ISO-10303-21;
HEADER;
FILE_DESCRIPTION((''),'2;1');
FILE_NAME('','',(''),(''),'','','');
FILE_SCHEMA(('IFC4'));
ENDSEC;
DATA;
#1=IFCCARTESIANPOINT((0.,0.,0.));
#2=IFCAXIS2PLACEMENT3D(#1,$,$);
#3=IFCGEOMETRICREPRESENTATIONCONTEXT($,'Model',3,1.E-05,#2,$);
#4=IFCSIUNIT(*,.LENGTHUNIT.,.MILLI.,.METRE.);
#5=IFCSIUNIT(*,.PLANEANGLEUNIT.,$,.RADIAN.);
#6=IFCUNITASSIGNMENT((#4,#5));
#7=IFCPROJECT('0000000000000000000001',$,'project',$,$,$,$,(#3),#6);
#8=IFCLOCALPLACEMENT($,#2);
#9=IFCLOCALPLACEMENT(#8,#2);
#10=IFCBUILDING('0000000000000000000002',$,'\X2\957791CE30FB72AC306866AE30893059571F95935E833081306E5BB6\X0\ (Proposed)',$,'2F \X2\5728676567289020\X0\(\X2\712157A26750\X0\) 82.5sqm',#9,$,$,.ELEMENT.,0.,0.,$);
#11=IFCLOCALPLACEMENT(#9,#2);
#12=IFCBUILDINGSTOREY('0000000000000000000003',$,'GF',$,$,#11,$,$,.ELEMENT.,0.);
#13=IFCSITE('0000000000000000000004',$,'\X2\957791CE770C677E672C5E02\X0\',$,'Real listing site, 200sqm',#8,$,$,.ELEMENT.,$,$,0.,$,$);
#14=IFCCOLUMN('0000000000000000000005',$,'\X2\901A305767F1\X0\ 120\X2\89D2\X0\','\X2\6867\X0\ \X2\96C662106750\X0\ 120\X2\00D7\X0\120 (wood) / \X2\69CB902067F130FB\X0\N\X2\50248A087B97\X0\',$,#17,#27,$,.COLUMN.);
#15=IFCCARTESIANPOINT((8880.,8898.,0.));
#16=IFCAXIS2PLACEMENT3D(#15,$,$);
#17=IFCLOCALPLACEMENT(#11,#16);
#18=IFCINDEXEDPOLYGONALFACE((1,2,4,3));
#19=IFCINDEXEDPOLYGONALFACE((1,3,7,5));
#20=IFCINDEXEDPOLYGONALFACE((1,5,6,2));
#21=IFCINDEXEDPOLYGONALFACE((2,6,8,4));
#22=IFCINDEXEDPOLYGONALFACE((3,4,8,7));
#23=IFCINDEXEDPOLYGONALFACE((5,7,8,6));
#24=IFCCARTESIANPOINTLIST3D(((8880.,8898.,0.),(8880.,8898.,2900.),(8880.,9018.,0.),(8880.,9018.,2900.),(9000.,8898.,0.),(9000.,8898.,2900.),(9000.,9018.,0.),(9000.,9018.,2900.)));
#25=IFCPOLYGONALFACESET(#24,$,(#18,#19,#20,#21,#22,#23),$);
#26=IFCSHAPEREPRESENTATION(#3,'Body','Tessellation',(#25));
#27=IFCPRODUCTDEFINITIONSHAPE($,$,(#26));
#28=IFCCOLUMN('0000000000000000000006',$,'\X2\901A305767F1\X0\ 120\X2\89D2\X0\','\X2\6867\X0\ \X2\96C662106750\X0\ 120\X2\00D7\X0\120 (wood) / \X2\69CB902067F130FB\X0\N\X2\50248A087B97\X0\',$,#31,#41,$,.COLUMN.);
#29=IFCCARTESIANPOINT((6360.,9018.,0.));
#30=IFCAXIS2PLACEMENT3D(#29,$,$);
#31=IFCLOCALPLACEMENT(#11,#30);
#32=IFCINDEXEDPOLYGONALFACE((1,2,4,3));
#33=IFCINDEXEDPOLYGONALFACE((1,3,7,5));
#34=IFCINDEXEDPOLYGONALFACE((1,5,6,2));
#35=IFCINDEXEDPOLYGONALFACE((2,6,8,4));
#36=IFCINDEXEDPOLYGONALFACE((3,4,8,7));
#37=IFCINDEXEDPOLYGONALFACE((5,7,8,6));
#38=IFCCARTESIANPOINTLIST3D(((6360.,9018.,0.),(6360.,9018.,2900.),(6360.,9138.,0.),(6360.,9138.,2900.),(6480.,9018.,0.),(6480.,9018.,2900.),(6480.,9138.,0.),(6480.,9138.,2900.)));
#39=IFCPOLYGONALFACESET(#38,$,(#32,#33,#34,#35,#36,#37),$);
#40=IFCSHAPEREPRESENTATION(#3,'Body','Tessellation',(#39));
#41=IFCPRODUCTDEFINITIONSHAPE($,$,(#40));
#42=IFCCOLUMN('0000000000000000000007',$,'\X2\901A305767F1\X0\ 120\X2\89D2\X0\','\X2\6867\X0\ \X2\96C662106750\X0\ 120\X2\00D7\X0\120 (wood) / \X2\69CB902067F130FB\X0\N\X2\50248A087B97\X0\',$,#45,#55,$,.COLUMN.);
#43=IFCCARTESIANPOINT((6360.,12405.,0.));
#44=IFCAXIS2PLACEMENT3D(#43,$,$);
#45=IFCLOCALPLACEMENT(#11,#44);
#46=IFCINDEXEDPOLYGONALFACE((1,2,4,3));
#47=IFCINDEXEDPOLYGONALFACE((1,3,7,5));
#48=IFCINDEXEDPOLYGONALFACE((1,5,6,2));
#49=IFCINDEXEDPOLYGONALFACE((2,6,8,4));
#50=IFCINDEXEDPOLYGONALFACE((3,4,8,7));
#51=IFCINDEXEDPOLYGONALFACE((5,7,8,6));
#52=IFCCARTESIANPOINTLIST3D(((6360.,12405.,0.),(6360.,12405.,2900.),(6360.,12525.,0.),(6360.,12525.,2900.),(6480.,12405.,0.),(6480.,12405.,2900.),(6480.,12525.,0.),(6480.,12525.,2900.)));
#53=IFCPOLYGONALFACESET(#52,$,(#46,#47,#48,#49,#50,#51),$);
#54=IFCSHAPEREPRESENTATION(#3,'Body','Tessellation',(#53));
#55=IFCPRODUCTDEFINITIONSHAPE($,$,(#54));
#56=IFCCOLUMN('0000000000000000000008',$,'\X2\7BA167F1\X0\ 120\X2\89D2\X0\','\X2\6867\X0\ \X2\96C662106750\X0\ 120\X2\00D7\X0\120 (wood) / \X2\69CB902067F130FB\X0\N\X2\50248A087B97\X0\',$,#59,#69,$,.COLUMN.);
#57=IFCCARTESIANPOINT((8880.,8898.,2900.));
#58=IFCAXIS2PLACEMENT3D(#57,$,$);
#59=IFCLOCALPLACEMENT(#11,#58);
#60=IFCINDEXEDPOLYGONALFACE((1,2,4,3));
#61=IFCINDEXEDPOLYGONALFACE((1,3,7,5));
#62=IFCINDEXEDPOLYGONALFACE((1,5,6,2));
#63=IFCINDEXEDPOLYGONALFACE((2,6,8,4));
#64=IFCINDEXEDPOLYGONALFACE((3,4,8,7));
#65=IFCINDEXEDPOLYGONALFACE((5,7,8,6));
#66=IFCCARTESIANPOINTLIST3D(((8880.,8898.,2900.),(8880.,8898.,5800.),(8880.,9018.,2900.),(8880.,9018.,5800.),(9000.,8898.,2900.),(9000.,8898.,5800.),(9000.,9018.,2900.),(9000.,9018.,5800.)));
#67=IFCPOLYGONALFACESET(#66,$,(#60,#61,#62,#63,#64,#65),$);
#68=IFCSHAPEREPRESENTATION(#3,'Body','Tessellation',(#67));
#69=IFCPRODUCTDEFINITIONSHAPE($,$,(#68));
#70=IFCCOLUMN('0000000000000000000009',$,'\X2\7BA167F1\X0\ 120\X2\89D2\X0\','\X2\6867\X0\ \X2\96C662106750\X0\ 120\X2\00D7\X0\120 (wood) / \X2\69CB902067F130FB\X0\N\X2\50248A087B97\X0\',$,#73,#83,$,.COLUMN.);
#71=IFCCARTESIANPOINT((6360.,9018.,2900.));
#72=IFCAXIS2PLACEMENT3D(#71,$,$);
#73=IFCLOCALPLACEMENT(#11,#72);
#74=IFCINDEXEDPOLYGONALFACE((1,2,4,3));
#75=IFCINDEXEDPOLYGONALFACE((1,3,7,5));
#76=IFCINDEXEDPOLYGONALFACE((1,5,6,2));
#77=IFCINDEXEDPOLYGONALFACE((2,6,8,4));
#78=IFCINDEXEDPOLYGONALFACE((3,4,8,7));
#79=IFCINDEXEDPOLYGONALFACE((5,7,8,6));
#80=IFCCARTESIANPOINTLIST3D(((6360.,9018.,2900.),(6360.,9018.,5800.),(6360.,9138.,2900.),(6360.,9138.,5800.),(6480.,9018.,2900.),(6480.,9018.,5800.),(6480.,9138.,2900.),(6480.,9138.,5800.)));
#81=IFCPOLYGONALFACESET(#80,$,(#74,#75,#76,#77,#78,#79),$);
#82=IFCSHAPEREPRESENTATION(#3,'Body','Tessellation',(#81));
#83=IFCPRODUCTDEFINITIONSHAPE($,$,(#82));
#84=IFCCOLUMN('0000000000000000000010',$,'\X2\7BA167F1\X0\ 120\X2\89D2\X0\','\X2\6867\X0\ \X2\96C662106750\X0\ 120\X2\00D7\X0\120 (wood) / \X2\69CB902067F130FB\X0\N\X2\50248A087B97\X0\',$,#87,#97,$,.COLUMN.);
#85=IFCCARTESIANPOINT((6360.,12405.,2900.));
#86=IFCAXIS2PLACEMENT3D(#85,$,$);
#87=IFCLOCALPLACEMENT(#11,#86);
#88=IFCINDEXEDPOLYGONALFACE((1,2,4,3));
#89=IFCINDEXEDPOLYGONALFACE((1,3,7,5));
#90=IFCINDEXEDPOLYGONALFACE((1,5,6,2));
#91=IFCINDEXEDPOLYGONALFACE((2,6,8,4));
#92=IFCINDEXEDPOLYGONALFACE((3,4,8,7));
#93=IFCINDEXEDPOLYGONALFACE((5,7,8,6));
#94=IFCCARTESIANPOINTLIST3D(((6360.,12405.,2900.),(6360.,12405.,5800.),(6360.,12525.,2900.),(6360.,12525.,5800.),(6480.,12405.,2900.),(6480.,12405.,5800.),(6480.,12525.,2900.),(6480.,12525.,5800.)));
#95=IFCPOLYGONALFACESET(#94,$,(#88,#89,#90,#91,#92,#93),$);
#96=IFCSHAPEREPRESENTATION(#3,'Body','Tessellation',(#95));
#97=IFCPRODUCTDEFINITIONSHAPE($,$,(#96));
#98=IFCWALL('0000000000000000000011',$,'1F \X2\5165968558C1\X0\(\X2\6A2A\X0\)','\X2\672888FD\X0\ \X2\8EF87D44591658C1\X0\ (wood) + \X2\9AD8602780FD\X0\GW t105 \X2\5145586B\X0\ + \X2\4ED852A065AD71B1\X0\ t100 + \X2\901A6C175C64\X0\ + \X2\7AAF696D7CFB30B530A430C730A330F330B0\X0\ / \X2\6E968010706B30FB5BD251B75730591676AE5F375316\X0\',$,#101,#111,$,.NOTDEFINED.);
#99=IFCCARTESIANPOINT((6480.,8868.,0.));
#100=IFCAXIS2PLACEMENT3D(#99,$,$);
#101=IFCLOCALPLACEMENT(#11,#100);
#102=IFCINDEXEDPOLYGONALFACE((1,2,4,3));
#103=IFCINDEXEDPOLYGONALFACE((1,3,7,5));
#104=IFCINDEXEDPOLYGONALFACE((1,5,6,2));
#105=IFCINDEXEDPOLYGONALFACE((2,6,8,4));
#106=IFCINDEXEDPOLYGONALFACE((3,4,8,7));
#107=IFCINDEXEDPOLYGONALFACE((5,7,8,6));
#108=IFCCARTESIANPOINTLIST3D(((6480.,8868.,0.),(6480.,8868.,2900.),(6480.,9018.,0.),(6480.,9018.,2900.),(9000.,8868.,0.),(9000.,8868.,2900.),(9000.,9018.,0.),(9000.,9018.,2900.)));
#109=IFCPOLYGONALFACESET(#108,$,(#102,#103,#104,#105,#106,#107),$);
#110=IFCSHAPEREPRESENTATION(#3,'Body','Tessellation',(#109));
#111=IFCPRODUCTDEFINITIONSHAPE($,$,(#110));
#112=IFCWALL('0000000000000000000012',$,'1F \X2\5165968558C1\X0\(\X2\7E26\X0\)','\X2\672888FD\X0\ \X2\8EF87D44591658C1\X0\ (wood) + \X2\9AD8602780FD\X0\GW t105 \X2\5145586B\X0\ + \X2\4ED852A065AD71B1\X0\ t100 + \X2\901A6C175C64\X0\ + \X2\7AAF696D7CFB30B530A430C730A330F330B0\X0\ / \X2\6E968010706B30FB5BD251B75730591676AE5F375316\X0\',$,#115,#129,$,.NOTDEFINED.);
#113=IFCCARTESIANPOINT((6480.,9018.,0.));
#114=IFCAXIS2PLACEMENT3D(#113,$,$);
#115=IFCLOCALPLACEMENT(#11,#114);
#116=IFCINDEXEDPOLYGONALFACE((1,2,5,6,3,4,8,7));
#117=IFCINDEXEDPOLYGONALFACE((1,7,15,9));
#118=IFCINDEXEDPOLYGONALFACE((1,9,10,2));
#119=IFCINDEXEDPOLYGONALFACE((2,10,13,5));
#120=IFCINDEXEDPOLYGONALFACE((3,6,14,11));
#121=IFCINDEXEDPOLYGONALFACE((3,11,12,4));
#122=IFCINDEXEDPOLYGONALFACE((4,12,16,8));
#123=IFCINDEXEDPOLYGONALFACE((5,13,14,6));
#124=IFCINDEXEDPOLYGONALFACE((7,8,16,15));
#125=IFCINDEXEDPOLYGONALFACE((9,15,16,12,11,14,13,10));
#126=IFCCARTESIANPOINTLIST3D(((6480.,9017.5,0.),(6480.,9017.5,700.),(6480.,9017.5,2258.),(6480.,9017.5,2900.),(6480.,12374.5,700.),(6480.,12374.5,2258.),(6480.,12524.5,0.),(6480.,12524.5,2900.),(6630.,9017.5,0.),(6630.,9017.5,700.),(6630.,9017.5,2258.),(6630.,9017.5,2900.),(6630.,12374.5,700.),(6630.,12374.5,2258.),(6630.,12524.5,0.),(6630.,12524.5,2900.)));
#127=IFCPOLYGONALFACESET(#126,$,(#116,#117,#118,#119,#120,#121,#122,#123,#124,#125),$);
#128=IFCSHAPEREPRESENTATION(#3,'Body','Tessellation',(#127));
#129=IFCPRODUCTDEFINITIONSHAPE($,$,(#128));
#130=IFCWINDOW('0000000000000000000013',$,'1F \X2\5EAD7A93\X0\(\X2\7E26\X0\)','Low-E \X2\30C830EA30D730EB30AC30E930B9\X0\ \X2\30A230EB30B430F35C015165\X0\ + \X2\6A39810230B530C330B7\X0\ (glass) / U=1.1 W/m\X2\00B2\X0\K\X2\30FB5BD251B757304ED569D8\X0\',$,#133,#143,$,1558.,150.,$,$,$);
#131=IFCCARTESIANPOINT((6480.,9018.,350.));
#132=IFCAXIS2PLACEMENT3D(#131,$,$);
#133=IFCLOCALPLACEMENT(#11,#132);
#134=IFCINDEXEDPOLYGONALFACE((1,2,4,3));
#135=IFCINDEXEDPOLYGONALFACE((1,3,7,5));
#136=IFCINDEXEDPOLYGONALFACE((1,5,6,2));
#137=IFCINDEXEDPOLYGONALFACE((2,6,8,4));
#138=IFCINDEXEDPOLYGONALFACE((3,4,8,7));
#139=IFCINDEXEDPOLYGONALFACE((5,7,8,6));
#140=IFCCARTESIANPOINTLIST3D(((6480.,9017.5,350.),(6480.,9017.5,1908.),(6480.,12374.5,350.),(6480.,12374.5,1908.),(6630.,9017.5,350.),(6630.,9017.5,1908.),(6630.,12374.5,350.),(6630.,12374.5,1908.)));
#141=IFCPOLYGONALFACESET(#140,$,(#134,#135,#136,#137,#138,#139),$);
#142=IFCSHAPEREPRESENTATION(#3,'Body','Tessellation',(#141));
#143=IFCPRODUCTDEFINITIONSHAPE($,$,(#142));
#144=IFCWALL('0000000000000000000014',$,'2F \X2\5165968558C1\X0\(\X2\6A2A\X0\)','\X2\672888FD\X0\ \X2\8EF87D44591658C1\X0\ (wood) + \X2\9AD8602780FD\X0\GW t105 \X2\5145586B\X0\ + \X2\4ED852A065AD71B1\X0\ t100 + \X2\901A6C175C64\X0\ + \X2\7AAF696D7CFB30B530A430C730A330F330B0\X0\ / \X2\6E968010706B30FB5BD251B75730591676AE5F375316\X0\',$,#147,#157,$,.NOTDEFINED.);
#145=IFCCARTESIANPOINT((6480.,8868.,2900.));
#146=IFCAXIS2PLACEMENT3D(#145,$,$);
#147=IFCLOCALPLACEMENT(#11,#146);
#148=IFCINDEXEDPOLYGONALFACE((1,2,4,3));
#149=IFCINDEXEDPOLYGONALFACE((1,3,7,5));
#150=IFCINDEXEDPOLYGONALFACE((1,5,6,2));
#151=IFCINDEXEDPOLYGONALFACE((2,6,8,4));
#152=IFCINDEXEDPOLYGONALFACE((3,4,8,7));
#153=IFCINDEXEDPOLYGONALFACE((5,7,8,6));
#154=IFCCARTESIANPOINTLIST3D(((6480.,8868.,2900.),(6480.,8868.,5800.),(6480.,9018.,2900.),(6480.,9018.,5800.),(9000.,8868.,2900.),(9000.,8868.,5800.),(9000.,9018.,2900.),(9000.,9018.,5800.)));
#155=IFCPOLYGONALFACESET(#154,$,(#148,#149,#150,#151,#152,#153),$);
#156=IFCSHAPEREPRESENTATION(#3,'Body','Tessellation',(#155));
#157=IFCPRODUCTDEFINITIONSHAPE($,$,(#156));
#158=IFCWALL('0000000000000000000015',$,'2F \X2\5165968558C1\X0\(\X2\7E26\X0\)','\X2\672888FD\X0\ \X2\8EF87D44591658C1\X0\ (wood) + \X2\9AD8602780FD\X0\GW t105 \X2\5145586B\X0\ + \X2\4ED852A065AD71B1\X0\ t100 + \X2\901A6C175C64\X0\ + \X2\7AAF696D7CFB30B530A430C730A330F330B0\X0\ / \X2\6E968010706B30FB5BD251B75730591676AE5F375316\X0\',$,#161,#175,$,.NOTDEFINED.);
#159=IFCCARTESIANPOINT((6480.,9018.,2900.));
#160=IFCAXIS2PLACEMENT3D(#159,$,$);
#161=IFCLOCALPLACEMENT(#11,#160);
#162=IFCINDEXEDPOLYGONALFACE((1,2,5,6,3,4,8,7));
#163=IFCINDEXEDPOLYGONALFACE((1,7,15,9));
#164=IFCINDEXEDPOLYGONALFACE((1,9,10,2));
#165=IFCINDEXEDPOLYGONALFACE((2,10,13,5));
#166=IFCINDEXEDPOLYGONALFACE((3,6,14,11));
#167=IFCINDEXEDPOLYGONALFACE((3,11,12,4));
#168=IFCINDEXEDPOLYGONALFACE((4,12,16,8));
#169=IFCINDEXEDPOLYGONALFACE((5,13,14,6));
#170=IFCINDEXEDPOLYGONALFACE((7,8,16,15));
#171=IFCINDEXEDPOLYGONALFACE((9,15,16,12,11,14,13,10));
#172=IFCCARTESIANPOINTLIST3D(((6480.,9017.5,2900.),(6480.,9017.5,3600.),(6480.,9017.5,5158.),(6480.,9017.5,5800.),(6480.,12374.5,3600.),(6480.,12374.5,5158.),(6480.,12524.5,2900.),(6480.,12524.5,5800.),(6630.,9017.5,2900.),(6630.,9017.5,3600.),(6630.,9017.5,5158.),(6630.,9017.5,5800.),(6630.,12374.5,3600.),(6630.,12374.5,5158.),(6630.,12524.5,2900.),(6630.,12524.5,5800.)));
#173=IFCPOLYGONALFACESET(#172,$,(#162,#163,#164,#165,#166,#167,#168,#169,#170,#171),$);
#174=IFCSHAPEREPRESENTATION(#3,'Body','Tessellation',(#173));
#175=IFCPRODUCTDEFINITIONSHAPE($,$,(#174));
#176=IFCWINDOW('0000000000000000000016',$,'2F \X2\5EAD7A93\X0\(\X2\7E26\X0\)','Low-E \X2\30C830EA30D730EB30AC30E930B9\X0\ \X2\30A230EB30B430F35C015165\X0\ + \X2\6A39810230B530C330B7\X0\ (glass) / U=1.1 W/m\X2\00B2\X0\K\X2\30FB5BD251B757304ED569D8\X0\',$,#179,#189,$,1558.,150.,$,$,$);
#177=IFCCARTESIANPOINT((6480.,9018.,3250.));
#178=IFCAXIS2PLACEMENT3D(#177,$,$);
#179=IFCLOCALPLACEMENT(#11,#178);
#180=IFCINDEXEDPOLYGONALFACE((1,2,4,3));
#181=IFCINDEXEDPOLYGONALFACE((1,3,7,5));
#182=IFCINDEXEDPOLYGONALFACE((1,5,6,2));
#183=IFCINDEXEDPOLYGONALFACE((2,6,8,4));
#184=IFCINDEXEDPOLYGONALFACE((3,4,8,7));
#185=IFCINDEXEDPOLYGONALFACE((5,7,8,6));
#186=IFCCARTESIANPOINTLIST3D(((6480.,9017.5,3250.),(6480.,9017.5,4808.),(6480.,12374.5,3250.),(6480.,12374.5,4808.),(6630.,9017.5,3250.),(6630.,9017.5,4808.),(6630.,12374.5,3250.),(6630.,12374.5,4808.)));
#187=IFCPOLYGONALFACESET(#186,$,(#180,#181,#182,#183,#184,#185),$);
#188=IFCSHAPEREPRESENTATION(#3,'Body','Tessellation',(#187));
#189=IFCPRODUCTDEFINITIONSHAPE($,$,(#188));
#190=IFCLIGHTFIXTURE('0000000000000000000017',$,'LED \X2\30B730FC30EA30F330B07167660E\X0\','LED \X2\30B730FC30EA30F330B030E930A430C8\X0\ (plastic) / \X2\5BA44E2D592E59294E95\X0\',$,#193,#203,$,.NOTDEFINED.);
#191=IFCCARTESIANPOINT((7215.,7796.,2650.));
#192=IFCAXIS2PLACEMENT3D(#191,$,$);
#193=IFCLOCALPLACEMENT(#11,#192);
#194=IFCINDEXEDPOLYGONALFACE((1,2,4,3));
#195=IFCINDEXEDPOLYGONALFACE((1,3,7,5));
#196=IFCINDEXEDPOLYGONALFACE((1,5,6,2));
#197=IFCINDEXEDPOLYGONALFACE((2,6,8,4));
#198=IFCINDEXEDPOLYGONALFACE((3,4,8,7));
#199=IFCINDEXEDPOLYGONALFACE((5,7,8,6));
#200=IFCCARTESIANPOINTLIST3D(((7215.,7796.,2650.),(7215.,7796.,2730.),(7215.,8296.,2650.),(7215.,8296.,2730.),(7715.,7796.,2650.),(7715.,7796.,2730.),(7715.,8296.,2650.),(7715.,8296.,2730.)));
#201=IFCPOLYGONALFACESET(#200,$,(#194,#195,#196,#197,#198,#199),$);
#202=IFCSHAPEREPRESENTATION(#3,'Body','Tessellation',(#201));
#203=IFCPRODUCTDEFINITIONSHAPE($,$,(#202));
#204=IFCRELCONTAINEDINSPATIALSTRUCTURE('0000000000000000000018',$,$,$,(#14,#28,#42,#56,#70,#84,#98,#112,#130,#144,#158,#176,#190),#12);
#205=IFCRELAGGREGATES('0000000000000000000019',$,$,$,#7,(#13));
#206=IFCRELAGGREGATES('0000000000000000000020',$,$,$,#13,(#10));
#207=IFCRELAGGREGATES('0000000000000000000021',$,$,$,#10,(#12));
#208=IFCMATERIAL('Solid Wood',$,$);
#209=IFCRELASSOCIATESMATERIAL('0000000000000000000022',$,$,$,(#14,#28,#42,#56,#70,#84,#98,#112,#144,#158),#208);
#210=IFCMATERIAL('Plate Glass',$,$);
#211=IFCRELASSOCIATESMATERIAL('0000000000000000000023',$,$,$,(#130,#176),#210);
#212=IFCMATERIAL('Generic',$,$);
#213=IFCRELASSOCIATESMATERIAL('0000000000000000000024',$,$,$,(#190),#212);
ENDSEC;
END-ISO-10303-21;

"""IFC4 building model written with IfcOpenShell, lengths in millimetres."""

from ifc_helpers import new_model, si_unit, frame, frame_2d, origin, place, context, project, spatial, rectangle, extrude, material, element, fill, save


model = new_model("IFC4")

# Units and contexts
model_context = context("Model", 3, precision=1e-05, world=origin())
ifc_project = project(units=[si_unit("LENGTHUNIT", "METRE", prefix="MILLI"), si_unit("PLANEANGLEUNIT", "RADIAN")], contexts=[model_context])

# Site, building, storey
site_placement = place(None, origin())
site = spatial("IfcSite", under=ifc_project, at=site_placement, Name="長野県松本市", ObjectType="Real listing site, 200sqm", CompositionType="ELEMENT", RefElevation=0.0)
building_placement = place(site_placement, origin())
building = spatial("IfcBuilding", under=site, at=building_placement, Name="長野・犬と暮らす土間広めの家 (Proposed)", ObjectType="2F 在来木造(無垢材) 82.5sqm", CompositionType="ELEMENT", ElevationOfRefHeight=0.0, ElevationOfTerrain=0.0)
storey_placement = place(building_placement, origin())
storey = spatial("IfcBuildingStorey", under=building, at=storey_placement, Name="GF", CompositionType="ELEMENT", Elevation=0.0)

# Columns
ifc_material_1 = material(Name="Solid Wood")
column_1_placement = place(storey_placement, frame((8880.0, 8898.0, 0.0)))
element("IfcColumn", 1, at=column_1_placement, inside=storey, material=ifc_material_1, Name="通し柱 120角", Description="桧 集成材 120×120 (wood) / 構造柱・N値計算", PredefinedType="COLUMN", context=model_context, shape_type="SweptSolid", body=[
    extrude(rectangle(XDim=120.0, YDim=120.0, at=frame_2d((60.0, 60.0))), frame((8880.0, 8898.0, 0.0)), (0.0, 0.0, 1.0), 2900.0),
])
column_2_placement = place(storey_placement, frame((6360.0, 9018.0, 0.0)))
element("IfcColumn", 2, at=column_2_placement, inside=storey, material=ifc_material_1, Name="通し柱 120角", Description="桧 集成材 120×120 (wood) / 構造柱・N値計算", PredefinedType="COLUMN", context=model_context, shape_type="SweptSolid", body=[
    extrude(rectangle(XDim=120.0, YDim=120.0, at=frame_2d((60.0, 60.0))), frame((6360.0, 9018.0, 0.0)), (0.0, 0.0, 1.0), 2900.0),
])
column_3_placement = place(storey_placement, frame((6360.0, 12405.0, 0.0)))
element("IfcColumn", 3, at=column_3_placement, inside=storey, material=ifc_material_1, Name="通し柱 120角", Description="桧 集成材 120×120 (wood) / 構造柱・N値計算", PredefinedType="COLUMN", context=model_context, shape_type="SweptSolid", body=[
    extrude(rectangle(XDim=120.0, YDim=120.0, at=frame_2d((60.0, 60.0))), frame((6360.0, 12405.0, 0.0)), (0.0, 0.0, 1.0), 2900.0),
])
column_4_placement = place(storey_placement, frame((8880.0, 8898.0, 2900.0)))
element("IfcColumn", 4, at=column_4_placement, inside=storey, material=ifc_material_1, Name="管柱 120角", Description="桧 集成材 120×120 (wood) / 構造柱・N値計算", PredefinedType="COLUMN", context=model_context, shape_type="SweptSolid", body=[
    extrude(rectangle(XDim=120.0, YDim=120.0, at=frame_2d((60.0, 60.0))), frame((8880.0, 8898.0, 2900.0)), (0.0, 0.0, 1.0), 2900.0),
])
column_5_placement = place(storey_placement, frame((6360.0, 9018.0, 2900.0)))
element("IfcColumn", 5, at=column_5_placement, inside=storey, material=ifc_material_1, Name="管柱 120角", Description="桧 集成材 120×120 (wood) / 構造柱・N値計算", PredefinedType="COLUMN", context=model_context, shape_type="SweptSolid", body=[
    extrude(rectangle(XDim=120.0, YDim=120.0, at=frame_2d((60.0, 60.0))), frame((6360.0, 9018.0, 2900.0)), (0.0, 0.0, 1.0), 2900.0),
])
column_6_placement = place(storey_placement, frame((6360.0, 12405.0, 2900.0)))
element("IfcColumn", 6, at=column_6_placement, inside=storey, material=ifc_material_1, Name="管柱 120角", Description="桧 集成材 120×120 (wood) / 構造柱・N値計算", PredefinedType="COLUMN", context=model_context, shape_type="SweptSolid", body=[
    extrude(rectangle(XDim=120.0, YDim=120.0, at=frame_2d((60.0, 60.0))), frame((6360.0, 12405.0, 2900.0)), (0.0, 0.0, 1.0), 2900.0),
])

# Wall
wall_1_placement = place(storey_placement, frame((6480.0, 8868.0, 0.0)))
element("IfcWall", 7, at=wall_1_placement, inside=storey, material=ifc_material_1, Name="1F 入隅壁(横)", Description="木製 軸組外壁 (wood) + 高性能GW t105 充填 + 付加断熱 t100 + 通気層 + 窯業系サイディング / 準耐火・寒冷地外皮強化", PredefinedType="NOTDEFINED", context=model_context, shape_type="SweptSolid", body=[
    extrude(rectangle(XDim=2520.0, YDim=150.0, at=frame_2d((1260.0, 75.0))), frame((6480.0, 8868.0, 0.0)), (0.0, 0.0, 1.0), 2900.0),
])

# Wall, opening, window
wall_2_placement = place(storey_placement, frame((6480.0, 9018.0, 0.0)))
wall_2 = element("IfcWall", 8, at=wall_2_placement, inside=storey, material=ifc_material_1, Name="1F 入隅壁(縦)", Description="木製 軸組外壁 (wood) + 高性能GW t105 充填 + 付加断熱 t100 + 通気層 + 窯業系サイディング / 準耐火・寒冷地外皮強化", PredefinedType="NOTDEFINED", context=model_context, shape_type="SweptSolid", body=[
    extrude(rectangle(XDim=150.0, YDim=3507.0, at=frame_2d((75.0, 1753.0))), frame((6480.0, 9018.0, 0.0)), (0.0, 0.0, 1.0), 2900.0),
])
opening_1_placement = place(storey_placement, frame((6480.0, 9018.0, 350.0)))
opening_1 = element("IfcOpeningElement", 9, at=opening_1_placement, cuts=wall_2, PredefinedType="NOTDEFINED", context=model_context, shape_type="SweptSolid", body=[
    extrude(rectangle(XDim=150.0, YDim=3357.0, at=frame_2d((75.0, 1678.0))), frame((6480.0, 9018.0, 350.0)), (0.0, 0.0, 1.0), 1558.0),
])
ifc_material_2 = material(Name="Plate Glass")
window_1_placement = place(storey_placement, frame((6480.0, 9018.0, 350.0)))
window_1 = element("IfcWindow", 10, at=window_1_placement, inside=storey, material=ifc_material_2, Name="1F 庭窓(縦)", Description="Low-E トリプルガラス アルゴン封入 + 樹脂サッシ (glass) / U=1.1 W/m²K・寒冷地仕様", OverallHeight=1558.0, OverallWidth=150.0, context=model_context, shape_type="SweptSolid", body=[
    extrude(rectangle(XDim=150.0, YDim=3357.0, at=frame_2d((75.0, 1678.0))), frame((6480.0, 9018.0, 350.0)), (0.0, 0.0, 1.0), 1558.0),
])
fill(opening_1, window_1)

# Wall
wall_3_placement = place(storey_placement, frame((6480.0, 8868.0, 2900.0)))
element("IfcWall", 11, at=wall_3_placement, inside=storey, material=ifc_material_1, Name="2F 入隅壁(横)", Description="木製 軸組外壁 (wood) + 高性能GW t105 充填 + 付加断熱 t100 + 通気層 + 窯業系サイディング / 準耐火・寒冷地外皮強化", PredefinedType="NOTDEFINED", context=model_context, shape_type="SweptSolid", body=[
    extrude(rectangle(XDim=2520.0, YDim=150.0, at=frame_2d((1260.0, 75.0))), frame((6480.0, 8868.0, 2900.0)), (0.0, 0.0, 1.0), 2900.0),
])

# Wall, opening, window
wall_4_placement = place(storey_placement, frame((6480.0, 9018.0, 2900.0)))
wall_4 = element("IfcWall", 12, at=wall_4_placement, inside=storey, material=ifc_material_1, Name="2F 入隅壁(縦)", Description="木製 軸組外壁 (wood) + 高性能GW t105 充填 + 付加断熱 t100 + 通気層 + 窯業系サイディング / 準耐火・寒冷地外皮強化", PredefinedType="NOTDEFINED", context=model_context, shape_type="SweptSolid", body=[
    extrude(rectangle(XDim=150.0, YDim=3507.0, at=frame_2d((75.0, 1753.0))), frame((6480.0, 9018.0, 2900.0)), (0.0, 0.0, 1.0), 2900.0),
])
opening_2_placement = place(storey_placement, frame((6480.0, 9018.0, 3250.0)))
opening_2 = element("IfcOpeningElement", 13, at=opening_2_placement, cuts=wall_4, PredefinedType="NOTDEFINED", context=model_context, shape_type="SweptSolid", body=[
    extrude(rectangle(XDim=150.0, YDim=3357.0, at=frame_2d((75.0, 1678.0))), frame((6480.0, 9018.0, 3250.0)), (0.0, 0.0, 1.0), 1558.0),
])
window_2_placement = place(storey_placement, frame((6480.0, 9018.0, 3250.0)))
window_2 = element("IfcWindow", 14, at=window_2_placement, inside=storey, material=ifc_material_2, Name="2F 庭窓(縦)", Description="Low-E トリプルガラス アルゴン封入 + 樹脂サッシ (glass) / U=1.1 W/m²K・寒冷地仕様", OverallHeight=1558.0, OverallWidth=150.0, context=model_context, shape_type="SweptSolid", body=[
    extrude(rectangle(XDim=150.0, YDim=3357.0, at=frame_2d((75.0, 1678.0))), frame((6480.0, 9018.0, 3250.0)), (0.0, 0.0, 1.0), 1558.0),
])
fill(opening_2, window_2)

# Light fixture
ifc_material_3 = material(Name="Generic")
light_fixture_placement = place(storey_placement, frame((7215.0, 7796.0, 2650.0)))
element("IfcLightFixture", 15, at=light_fixture_placement, inside=storey, material=ifc_material_3, Name="LED シーリング照明", Description="LED シーリングライト (plastic) / 室中央天井", PredefinedType="NOTDEFINED", context=model_context, shape_type="SweptSolid", body=[
    extrude(rectangle(XDim=500.0, YDim=500.0, at=frame_2d((250.0, 250.0))), frame((7215.0, 7796.0, 2650.0)), (0.0, 0.0, 1.0), 80.0),
])

save(model, "model.ifc")
